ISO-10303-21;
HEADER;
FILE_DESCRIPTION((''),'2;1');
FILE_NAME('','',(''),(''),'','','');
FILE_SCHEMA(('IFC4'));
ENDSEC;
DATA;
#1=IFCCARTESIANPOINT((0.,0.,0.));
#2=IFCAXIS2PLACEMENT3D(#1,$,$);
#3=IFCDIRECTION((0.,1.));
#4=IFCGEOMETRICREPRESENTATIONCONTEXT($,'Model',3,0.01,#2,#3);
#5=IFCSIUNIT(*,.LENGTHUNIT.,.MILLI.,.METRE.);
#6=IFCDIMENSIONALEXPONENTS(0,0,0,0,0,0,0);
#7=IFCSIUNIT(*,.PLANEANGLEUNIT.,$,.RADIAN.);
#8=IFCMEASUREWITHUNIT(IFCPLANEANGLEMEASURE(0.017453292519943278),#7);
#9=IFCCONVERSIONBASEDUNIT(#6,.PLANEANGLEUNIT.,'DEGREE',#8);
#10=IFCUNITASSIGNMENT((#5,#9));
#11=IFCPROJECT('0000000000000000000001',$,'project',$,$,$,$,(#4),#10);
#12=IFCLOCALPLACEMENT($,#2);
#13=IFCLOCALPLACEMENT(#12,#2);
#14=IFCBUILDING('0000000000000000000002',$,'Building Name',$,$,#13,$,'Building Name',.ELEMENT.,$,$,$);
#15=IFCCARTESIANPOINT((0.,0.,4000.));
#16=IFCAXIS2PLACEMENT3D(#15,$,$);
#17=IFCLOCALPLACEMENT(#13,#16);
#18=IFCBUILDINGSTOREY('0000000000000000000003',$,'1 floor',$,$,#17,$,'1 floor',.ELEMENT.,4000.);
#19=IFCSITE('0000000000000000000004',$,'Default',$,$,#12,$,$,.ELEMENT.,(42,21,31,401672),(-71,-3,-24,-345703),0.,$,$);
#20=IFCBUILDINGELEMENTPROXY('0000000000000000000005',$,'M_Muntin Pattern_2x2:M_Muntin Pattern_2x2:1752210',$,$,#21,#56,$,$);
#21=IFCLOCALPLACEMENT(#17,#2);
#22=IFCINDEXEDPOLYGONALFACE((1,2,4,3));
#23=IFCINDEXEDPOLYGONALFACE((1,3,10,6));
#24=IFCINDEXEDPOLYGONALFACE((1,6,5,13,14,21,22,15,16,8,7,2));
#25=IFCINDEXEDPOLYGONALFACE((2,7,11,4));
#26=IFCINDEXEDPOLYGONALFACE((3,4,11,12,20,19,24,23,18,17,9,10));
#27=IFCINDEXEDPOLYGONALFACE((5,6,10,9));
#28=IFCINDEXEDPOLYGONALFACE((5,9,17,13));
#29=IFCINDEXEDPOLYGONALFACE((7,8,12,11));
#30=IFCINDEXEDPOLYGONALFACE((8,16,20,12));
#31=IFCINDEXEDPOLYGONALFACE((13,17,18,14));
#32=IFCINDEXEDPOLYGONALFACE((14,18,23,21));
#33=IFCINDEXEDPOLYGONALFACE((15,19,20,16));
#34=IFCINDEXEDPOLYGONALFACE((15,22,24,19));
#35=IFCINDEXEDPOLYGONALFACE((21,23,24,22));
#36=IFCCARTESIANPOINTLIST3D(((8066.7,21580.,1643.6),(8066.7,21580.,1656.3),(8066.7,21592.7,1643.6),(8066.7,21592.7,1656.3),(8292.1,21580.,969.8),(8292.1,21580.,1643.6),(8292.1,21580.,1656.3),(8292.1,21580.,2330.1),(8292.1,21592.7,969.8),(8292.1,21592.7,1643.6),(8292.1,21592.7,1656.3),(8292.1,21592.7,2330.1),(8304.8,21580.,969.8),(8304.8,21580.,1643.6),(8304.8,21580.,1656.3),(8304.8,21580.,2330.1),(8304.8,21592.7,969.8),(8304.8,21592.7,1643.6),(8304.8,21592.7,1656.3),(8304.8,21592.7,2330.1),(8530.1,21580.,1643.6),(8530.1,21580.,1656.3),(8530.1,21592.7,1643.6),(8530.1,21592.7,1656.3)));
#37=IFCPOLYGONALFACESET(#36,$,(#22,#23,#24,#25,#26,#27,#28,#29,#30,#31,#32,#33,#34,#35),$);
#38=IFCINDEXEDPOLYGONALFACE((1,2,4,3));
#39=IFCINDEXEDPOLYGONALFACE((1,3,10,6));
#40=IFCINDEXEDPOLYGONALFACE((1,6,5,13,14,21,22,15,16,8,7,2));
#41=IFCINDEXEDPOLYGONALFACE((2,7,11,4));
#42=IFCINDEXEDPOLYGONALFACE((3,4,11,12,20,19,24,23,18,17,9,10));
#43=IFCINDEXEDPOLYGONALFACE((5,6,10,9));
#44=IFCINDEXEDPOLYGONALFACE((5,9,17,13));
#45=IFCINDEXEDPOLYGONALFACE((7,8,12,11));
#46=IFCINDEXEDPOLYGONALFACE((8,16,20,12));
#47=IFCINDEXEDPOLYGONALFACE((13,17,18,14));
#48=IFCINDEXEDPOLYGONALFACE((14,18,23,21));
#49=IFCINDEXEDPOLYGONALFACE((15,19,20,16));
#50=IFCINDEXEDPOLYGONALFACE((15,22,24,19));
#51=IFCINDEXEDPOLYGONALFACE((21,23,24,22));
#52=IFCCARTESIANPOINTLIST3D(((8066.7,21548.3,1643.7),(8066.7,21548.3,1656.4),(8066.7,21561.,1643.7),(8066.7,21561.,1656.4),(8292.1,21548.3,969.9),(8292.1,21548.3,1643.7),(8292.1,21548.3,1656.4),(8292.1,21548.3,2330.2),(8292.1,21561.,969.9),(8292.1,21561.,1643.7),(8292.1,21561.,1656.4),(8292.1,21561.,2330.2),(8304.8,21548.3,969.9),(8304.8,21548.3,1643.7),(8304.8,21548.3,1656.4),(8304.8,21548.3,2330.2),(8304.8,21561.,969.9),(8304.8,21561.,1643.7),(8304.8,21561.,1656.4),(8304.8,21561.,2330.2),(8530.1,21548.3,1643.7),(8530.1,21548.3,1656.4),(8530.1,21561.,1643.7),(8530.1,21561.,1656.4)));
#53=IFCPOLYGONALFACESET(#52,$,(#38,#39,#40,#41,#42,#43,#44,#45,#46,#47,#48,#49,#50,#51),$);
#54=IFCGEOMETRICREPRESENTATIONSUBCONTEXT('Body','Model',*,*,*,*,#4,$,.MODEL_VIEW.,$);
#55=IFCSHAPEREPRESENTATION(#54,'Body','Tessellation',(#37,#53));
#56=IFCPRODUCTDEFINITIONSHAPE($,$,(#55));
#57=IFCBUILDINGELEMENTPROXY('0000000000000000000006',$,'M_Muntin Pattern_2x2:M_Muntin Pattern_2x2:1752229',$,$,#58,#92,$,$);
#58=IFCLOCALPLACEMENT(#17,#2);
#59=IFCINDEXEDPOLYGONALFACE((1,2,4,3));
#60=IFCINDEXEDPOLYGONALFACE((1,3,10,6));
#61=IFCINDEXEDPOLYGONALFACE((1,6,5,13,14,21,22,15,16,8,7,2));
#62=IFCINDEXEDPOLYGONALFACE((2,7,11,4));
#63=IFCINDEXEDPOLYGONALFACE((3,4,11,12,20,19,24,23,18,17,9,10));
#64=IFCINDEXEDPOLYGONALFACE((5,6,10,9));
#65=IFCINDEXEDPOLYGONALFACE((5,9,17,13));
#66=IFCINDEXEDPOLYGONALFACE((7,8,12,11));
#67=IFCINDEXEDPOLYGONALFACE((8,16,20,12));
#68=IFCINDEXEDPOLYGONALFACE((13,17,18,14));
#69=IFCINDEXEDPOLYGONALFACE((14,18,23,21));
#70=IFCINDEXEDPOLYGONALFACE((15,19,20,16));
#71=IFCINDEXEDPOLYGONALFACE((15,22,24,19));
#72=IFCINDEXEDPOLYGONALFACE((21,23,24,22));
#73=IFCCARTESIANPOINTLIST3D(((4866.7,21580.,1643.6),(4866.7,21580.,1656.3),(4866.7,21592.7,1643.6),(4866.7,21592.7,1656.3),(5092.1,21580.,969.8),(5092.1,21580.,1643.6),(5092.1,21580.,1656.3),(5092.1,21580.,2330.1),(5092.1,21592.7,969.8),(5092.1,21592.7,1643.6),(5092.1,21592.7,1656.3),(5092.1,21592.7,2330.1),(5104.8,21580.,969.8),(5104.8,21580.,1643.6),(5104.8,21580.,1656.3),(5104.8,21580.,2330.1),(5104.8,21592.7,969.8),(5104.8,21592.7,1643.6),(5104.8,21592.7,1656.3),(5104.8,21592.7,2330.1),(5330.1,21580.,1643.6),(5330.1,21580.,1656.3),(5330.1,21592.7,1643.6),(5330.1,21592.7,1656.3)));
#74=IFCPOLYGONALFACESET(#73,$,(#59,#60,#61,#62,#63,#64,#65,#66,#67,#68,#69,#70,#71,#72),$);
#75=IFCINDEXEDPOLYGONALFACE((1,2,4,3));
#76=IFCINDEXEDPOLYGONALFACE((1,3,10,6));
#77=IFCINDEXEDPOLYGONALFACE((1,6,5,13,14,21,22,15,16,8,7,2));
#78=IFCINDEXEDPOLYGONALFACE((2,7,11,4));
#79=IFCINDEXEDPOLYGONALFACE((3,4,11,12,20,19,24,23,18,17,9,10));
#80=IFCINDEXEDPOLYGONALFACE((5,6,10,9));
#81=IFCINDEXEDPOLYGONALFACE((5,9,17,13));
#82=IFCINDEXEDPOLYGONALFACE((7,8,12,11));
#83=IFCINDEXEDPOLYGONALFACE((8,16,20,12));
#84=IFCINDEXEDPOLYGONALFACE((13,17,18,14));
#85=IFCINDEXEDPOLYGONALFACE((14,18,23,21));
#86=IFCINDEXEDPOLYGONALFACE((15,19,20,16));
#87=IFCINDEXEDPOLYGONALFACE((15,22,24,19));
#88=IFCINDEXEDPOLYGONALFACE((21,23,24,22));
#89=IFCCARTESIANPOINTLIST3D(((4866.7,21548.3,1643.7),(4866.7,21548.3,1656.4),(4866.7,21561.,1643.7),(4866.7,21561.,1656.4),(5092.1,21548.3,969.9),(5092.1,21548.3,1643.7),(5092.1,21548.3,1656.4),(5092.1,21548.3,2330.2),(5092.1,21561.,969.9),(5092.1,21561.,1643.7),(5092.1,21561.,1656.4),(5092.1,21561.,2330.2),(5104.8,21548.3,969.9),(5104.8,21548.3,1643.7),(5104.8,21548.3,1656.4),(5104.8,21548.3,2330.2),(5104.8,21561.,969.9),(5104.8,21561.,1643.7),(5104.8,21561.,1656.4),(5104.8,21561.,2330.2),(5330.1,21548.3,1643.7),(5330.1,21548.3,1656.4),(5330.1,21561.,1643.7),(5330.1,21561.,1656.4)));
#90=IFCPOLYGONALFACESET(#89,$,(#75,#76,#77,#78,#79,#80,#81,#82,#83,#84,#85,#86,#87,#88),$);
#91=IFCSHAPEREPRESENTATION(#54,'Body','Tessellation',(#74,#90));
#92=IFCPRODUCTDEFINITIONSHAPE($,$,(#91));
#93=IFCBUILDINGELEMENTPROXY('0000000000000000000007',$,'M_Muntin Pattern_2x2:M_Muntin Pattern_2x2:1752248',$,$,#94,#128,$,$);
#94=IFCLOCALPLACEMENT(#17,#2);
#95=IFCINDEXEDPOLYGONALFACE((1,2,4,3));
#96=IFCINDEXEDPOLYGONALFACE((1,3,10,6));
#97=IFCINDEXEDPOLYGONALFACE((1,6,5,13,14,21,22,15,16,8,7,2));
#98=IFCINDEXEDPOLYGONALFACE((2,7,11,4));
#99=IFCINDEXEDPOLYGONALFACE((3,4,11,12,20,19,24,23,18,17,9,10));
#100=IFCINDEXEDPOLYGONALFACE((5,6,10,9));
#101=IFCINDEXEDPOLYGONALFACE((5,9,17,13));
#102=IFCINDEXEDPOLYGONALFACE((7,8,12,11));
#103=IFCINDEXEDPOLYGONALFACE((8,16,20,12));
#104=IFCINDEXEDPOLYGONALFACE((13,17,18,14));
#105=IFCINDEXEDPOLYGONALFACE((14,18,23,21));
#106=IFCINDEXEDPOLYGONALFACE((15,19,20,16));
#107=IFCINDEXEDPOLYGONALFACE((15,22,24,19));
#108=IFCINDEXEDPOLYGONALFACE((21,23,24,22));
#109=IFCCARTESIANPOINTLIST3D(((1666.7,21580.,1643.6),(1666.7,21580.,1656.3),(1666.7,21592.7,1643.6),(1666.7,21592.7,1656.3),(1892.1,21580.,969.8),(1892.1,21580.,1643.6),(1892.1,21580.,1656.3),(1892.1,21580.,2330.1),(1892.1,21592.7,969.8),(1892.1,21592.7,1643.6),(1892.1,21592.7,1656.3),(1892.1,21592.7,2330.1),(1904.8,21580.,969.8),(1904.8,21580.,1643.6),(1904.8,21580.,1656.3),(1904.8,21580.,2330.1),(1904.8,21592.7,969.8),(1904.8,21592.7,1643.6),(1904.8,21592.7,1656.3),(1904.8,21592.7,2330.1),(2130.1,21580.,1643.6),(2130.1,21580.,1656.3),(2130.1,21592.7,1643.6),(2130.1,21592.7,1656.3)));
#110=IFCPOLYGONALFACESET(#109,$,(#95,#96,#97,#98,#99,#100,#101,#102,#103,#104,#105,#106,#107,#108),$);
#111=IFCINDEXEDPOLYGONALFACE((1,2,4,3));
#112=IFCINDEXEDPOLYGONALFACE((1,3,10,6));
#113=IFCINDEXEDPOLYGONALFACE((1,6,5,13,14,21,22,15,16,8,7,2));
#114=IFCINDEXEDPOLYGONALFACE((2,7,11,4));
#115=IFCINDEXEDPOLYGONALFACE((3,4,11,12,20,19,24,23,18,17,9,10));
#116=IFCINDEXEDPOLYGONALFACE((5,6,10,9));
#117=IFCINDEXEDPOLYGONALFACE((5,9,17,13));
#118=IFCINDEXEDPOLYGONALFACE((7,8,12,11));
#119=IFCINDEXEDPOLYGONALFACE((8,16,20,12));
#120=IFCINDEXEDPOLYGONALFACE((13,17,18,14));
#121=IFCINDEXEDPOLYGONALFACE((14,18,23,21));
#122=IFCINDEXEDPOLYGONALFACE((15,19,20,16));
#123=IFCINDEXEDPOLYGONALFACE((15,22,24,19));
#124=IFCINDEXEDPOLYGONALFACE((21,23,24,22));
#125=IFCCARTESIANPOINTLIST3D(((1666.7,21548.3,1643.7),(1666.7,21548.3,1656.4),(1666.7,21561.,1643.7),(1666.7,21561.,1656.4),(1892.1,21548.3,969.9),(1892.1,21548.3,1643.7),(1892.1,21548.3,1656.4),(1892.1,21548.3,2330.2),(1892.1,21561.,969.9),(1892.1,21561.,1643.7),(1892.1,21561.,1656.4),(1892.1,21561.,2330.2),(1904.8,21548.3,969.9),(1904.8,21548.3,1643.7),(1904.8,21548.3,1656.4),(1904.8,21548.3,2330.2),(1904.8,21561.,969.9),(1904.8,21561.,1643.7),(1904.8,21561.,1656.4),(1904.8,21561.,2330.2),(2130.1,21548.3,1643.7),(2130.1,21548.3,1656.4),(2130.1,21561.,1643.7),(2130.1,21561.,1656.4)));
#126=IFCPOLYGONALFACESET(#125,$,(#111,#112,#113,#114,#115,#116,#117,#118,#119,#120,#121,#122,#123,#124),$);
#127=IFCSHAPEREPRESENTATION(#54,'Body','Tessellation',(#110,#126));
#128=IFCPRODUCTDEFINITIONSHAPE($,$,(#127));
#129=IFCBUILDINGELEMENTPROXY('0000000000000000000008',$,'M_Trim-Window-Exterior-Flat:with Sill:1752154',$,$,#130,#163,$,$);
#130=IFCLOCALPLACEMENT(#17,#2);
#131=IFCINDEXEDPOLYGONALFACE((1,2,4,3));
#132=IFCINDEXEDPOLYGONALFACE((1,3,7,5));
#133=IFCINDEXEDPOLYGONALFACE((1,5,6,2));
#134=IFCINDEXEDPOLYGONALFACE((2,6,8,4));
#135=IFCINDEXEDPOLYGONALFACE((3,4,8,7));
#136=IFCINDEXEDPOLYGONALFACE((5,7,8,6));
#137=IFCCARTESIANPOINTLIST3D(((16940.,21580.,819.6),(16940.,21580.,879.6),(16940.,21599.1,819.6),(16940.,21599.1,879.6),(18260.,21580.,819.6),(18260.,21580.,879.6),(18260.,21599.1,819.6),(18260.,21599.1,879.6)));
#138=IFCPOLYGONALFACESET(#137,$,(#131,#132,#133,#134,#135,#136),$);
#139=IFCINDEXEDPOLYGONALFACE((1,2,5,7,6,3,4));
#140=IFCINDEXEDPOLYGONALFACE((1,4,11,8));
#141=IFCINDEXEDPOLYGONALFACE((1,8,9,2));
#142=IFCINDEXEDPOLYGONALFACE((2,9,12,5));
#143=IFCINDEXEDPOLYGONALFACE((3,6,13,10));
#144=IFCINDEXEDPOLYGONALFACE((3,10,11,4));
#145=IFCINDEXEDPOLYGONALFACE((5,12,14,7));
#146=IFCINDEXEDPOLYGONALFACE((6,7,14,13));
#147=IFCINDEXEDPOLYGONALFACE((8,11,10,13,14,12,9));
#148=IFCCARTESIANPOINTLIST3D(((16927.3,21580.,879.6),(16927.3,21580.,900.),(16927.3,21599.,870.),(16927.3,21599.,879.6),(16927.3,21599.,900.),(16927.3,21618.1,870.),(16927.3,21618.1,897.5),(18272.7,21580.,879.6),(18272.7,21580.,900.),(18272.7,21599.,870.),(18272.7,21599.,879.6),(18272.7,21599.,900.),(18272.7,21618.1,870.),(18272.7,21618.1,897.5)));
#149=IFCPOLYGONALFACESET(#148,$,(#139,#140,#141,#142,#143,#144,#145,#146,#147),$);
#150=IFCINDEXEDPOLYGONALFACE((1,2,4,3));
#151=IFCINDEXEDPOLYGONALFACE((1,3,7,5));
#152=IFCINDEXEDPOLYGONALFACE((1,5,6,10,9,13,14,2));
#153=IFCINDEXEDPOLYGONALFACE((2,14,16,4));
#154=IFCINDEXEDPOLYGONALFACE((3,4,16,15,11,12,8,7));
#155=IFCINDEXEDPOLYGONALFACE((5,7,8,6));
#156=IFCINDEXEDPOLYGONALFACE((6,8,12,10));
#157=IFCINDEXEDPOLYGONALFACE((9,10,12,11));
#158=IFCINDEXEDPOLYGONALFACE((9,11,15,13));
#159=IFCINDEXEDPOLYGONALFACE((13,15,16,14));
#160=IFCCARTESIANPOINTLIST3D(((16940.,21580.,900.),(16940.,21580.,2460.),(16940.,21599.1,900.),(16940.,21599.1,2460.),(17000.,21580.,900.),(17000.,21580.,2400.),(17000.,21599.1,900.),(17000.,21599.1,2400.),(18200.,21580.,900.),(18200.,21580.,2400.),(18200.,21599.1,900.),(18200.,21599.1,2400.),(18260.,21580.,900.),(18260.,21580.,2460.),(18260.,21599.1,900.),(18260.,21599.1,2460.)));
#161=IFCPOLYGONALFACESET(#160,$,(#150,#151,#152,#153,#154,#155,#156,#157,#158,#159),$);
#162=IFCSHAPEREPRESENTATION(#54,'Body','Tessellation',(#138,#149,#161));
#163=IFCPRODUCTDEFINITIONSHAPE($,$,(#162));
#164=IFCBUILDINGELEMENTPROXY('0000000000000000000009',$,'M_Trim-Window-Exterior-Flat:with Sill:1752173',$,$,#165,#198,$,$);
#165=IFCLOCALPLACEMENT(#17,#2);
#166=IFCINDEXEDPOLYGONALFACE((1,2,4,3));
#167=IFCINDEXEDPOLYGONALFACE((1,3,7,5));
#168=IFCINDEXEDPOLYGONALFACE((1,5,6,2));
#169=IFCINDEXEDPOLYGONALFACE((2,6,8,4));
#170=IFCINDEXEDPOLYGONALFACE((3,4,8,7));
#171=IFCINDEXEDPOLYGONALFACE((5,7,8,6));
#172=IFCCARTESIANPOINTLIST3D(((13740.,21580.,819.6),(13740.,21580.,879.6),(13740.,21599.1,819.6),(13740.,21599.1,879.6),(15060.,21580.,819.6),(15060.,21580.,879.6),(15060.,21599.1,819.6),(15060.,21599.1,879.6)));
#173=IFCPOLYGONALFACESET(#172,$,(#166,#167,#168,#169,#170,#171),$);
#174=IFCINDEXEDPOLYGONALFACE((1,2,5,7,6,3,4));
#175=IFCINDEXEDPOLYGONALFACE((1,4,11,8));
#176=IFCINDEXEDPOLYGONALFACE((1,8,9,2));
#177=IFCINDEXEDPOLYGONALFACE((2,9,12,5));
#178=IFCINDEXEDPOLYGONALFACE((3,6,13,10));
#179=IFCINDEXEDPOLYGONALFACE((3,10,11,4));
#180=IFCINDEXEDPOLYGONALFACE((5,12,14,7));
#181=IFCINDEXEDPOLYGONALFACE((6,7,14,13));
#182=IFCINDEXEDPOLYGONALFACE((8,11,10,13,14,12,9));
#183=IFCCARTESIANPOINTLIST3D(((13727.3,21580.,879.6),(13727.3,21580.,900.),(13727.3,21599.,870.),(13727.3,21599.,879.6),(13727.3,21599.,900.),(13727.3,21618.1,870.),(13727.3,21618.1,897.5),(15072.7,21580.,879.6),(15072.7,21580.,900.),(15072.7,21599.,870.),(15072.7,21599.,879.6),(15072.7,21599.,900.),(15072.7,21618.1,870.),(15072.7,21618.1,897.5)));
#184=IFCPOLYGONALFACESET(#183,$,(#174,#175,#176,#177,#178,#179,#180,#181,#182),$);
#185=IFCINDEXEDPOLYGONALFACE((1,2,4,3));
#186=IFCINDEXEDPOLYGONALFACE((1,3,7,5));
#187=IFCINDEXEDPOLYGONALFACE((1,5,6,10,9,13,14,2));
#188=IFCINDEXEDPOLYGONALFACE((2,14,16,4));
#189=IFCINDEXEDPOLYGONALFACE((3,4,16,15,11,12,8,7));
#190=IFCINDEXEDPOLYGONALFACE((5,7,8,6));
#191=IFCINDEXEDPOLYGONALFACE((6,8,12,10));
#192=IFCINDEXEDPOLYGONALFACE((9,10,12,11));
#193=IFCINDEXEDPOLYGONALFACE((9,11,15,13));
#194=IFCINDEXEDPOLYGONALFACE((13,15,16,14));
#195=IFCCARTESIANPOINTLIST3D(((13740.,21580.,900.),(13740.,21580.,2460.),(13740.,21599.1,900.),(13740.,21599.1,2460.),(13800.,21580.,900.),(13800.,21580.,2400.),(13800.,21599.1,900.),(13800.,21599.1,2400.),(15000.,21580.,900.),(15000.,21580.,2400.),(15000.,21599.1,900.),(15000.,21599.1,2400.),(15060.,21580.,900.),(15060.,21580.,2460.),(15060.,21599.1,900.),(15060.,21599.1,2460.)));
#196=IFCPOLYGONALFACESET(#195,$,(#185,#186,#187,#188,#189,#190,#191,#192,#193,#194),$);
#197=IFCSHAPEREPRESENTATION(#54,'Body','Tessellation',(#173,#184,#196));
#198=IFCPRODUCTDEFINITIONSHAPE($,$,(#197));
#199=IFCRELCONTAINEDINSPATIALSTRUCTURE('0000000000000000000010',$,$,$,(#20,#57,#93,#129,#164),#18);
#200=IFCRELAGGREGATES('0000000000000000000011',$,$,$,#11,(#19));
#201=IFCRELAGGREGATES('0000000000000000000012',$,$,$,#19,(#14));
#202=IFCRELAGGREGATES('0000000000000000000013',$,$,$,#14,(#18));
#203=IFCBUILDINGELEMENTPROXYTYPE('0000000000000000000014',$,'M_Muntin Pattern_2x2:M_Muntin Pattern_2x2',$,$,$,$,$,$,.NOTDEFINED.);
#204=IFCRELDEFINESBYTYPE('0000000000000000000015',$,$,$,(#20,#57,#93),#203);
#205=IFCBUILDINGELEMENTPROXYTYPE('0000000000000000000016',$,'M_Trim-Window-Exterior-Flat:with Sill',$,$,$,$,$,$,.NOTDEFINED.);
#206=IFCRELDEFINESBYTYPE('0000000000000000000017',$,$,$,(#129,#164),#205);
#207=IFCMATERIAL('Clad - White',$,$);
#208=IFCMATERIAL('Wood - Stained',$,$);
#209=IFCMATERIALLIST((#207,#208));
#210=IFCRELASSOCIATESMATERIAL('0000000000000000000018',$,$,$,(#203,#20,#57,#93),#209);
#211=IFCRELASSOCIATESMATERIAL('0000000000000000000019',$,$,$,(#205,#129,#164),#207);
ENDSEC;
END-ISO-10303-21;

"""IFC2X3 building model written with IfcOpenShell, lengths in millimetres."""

from ifc_helpers import new_model, entity, si_unit, converted_unit, direction, frame, frame_2d, origin, place, context, subcontext, project, spatial, polyline, rectangle, outline, extrude, source, transform, mapped, material, material_list, type_object, type_shapes, element, save


model = new_model("IFC2X3")

# Units and contexts
model_context = context("Model", 3, precision=0.01, world=origin(), true_north=direction((0.0, 1.0)))
body_context = subcontext(model_context, "Body", "Model", "MODEL_VIEW")
ifc_project = project(units=[si_unit("LENGTHUNIT", "METRE", prefix="MILLI"), converted_unit("PLANEANGLEUNIT", "DEGREE", entity("IfcPlaneAngleMeasure", 0.017453292519943278), si_unit("PLANEANGLEUNIT", "RADIAN"), dimensions=[0, 0, 0, 0, 0, 0, 0])], contexts=[model_context])

# Site, building, storey
site_placement = place(None, origin())
site = spatial("IfcSite", under=ifc_project, at=site_placement, Name="Default", CompositionType="ELEMENT", RefLatitude=(42, 21, 31, 401672), RefLongitude=(-71, -3, -24, -345703), RefElevation=0.0)
building_placement = place(site_placement, origin())
building = spatial("IfcBuilding", under=site, at=building_placement, Name="Building Name", LongName="Building Name", CompositionType="ELEMENT")
storey_placement = place(building_placement, frame((0.0, 0.0, 4000.0)))
storey = spatial("IfcBuildingStorey", under=building, at=storey_placement, Name="1 floor", LongName="1 floor", CompositionType="ELEMENT", Elevation=4000.0)

# Building element proxies
ifc_material_1 = material(Name="Clad - White")
ifc_material_2 = material(Name="Wood - Stained")
ifc_material_list = material_list([ifc_material_1, ifc_material_2])
building_element_proxy_type_1 = type_object("IfcBuildingElementProxyType", Name="M_Muntin Pattern_2x2:M_Muntin Pattern_2x2", PredefinedType="NOTDEFINED", material=ifc_material_list)
shared_shape_1 = source(origin(), body_context, "Body", "SweptSolid", [
    extrude(outline(polyline([(6.4, -6.4), (680.1, -6.4), (680.1, 6.3), (6.4, 6.3), (6.4, 231.7), (-6.3, 231.7), (-6.3, 6.3), (-680.2, 6.3), (-680.2, -6.4), (-6.3, -6.4), (-6.3, -231.7), (6.4, -231.7), (6.4, -6.4)])), frame((0.0, -22.2, 680.1), z_axis=(0.0, 1.0, 0.0), x_axis=(0.0, 0.0, 1.0)), (0.0, 0.0, 1.0), 12.7),
    extrude(outline(polyline([(6.4, -6.4), (680.2, -6.4), (680.2, 6.3), (6.4, 6.3), (6.4, 231.7), (-6.3, 231.7), (-6.3, 6.3), (-680.2, 6.3), (-680.2, -6.4), (-6.3, -6.4), (-6.3, -231.7), (6.4, -231.7), (6.4, -6.4)])), frame((0.0, 9.5, 680.2), z_axis=(0.0, 1.0, 0.0), x_axis=(0.0, 0.0, 1.0)), (0.0, 0.0, 1.0), 12.7),
])
type_shapes(building_element_proxy_type_1, [shared_shape_1])
for number, where, z_axis, x_axis, name in (
    (1, (8298.4, 21570.5, 969.9), (0.0, 0.0, 1.0), (-1.0, 0.0, 0.0), "M_Muntin Pattern_2x2:M_Muntin Pattern_2x2:1752210"),
    (2, (5098.4, 21570.5, 969.9), (0.0, 0.0, 1.0), (-1.0, 0.0, 0.0), "M_Muntin Pattern_2x2:M_Muntin Pattern_2x2:1752229"),
    (3, (1898.4, 21570.5, 969.9), (0.0, 0.0, 1.0), (-1.0, 0.0, 0.0), "M_Muntin Pattern_2x2:M_Muntin Pattern_2x2:1752248"),
):
    element("IfcBuildingElementProxy", number, at=place(storey_placement, frame(where, z_axis=z_axis, x_axis=x_axis)), inside=storey, type_object=building_element_proxy_type_1, material=ifc_material_list, Name=name, context=body_context, shape_type="MappedRepresentation", body=[
        mapped(shared_shape_1, transform((0.0, 0.0, 0.0), scale=1.0)),
    ])
building_element_proxy_type_2 = type_object("IfcBuildingElementProxyType", Name="M_Trim-Window-Exterior-Flat:with Sill", PredefinedType="NOTDEFINED", material=ifc_material_1)
shared_shape_2 = source(origin(), body_context, "Body", "SweptSolid", [
    extrude(rectangle(XDim=1320.0, YDim=60.0, at=frame_2d((0.0, 0.0), x_axis=(1.0, 0.0))), frame((0.0, -1550.4, 0.0), z_axis=(0.0, 0.0, 1.0), x_axis=(-1.0, 0.0, 0.0)), (0.0, 0.0, 1.0), 19.0),
    extrude(outline(polyline([(-19.0, -15.2), (0.0, -15.2), (0.0, -5.7), (19.0, -5.7), (19.0, 14.8), (0.0, 14.8), (-19.0, 12.3), (-19.0, -15.2)])), frame((-672.7, -1514.8, 19.0), z_axis=(1.0, 0.0, 0.0), x_axis=(0.0, 0.0, -1.0)), (0.0, 0.0, 1.0), 1345.4),
    extrude(outline(polyline([(-795.0, -660.0), (765.0, -660.0), (765.0, -600.0), (-735.0, -600.0), (-735.0, 600.0), (765.0, 600.0), (765.0, 660.0), (-795.0, 660.0), (-795.0, -660.0)])), frame((0.0, -735.0, 0.0), z_axis=(0.0, 0.0, 1.0), x_axis=(0.0, -1.0, 0.0)), (0.0, 0.0, 1.0), 19.0),
])
type_shapes(building_element_proxy_type_2, [shared_shape_2])
for number, where, z_axis, x_axis, name in (
    (4, (17600.0, 21580.0, 2400.0), (0.0, 1.0, 0.0), (-1.0, 0.0, 0.0), "M_Trim-Window-Exterior-Flat:with Sill:1752154"),
    (5, (14400.0, 21580.0, 2400.0), (0.0, 1.0, 0.0), (-1.0, 0.0, 0.0), "M_Trim-Window-Exterior-Flat:with Sill:1752173"),
):
    element("IfcBuildingElementProxy", number, at=place(storey_placement, frame(where, z_axis=z_axis, x_axis=x_axis)), inside=storey, type_object=building_element_proxy_type_2, material=ifc_material_1, Name=name, context=body_context, shape_type="MappedRepresentation", body=[
        mapped(shared_shape_2, transform((0.0, 0.0, 0.0), scale=1.0)),
    ])

save(model, "model.ifc")
